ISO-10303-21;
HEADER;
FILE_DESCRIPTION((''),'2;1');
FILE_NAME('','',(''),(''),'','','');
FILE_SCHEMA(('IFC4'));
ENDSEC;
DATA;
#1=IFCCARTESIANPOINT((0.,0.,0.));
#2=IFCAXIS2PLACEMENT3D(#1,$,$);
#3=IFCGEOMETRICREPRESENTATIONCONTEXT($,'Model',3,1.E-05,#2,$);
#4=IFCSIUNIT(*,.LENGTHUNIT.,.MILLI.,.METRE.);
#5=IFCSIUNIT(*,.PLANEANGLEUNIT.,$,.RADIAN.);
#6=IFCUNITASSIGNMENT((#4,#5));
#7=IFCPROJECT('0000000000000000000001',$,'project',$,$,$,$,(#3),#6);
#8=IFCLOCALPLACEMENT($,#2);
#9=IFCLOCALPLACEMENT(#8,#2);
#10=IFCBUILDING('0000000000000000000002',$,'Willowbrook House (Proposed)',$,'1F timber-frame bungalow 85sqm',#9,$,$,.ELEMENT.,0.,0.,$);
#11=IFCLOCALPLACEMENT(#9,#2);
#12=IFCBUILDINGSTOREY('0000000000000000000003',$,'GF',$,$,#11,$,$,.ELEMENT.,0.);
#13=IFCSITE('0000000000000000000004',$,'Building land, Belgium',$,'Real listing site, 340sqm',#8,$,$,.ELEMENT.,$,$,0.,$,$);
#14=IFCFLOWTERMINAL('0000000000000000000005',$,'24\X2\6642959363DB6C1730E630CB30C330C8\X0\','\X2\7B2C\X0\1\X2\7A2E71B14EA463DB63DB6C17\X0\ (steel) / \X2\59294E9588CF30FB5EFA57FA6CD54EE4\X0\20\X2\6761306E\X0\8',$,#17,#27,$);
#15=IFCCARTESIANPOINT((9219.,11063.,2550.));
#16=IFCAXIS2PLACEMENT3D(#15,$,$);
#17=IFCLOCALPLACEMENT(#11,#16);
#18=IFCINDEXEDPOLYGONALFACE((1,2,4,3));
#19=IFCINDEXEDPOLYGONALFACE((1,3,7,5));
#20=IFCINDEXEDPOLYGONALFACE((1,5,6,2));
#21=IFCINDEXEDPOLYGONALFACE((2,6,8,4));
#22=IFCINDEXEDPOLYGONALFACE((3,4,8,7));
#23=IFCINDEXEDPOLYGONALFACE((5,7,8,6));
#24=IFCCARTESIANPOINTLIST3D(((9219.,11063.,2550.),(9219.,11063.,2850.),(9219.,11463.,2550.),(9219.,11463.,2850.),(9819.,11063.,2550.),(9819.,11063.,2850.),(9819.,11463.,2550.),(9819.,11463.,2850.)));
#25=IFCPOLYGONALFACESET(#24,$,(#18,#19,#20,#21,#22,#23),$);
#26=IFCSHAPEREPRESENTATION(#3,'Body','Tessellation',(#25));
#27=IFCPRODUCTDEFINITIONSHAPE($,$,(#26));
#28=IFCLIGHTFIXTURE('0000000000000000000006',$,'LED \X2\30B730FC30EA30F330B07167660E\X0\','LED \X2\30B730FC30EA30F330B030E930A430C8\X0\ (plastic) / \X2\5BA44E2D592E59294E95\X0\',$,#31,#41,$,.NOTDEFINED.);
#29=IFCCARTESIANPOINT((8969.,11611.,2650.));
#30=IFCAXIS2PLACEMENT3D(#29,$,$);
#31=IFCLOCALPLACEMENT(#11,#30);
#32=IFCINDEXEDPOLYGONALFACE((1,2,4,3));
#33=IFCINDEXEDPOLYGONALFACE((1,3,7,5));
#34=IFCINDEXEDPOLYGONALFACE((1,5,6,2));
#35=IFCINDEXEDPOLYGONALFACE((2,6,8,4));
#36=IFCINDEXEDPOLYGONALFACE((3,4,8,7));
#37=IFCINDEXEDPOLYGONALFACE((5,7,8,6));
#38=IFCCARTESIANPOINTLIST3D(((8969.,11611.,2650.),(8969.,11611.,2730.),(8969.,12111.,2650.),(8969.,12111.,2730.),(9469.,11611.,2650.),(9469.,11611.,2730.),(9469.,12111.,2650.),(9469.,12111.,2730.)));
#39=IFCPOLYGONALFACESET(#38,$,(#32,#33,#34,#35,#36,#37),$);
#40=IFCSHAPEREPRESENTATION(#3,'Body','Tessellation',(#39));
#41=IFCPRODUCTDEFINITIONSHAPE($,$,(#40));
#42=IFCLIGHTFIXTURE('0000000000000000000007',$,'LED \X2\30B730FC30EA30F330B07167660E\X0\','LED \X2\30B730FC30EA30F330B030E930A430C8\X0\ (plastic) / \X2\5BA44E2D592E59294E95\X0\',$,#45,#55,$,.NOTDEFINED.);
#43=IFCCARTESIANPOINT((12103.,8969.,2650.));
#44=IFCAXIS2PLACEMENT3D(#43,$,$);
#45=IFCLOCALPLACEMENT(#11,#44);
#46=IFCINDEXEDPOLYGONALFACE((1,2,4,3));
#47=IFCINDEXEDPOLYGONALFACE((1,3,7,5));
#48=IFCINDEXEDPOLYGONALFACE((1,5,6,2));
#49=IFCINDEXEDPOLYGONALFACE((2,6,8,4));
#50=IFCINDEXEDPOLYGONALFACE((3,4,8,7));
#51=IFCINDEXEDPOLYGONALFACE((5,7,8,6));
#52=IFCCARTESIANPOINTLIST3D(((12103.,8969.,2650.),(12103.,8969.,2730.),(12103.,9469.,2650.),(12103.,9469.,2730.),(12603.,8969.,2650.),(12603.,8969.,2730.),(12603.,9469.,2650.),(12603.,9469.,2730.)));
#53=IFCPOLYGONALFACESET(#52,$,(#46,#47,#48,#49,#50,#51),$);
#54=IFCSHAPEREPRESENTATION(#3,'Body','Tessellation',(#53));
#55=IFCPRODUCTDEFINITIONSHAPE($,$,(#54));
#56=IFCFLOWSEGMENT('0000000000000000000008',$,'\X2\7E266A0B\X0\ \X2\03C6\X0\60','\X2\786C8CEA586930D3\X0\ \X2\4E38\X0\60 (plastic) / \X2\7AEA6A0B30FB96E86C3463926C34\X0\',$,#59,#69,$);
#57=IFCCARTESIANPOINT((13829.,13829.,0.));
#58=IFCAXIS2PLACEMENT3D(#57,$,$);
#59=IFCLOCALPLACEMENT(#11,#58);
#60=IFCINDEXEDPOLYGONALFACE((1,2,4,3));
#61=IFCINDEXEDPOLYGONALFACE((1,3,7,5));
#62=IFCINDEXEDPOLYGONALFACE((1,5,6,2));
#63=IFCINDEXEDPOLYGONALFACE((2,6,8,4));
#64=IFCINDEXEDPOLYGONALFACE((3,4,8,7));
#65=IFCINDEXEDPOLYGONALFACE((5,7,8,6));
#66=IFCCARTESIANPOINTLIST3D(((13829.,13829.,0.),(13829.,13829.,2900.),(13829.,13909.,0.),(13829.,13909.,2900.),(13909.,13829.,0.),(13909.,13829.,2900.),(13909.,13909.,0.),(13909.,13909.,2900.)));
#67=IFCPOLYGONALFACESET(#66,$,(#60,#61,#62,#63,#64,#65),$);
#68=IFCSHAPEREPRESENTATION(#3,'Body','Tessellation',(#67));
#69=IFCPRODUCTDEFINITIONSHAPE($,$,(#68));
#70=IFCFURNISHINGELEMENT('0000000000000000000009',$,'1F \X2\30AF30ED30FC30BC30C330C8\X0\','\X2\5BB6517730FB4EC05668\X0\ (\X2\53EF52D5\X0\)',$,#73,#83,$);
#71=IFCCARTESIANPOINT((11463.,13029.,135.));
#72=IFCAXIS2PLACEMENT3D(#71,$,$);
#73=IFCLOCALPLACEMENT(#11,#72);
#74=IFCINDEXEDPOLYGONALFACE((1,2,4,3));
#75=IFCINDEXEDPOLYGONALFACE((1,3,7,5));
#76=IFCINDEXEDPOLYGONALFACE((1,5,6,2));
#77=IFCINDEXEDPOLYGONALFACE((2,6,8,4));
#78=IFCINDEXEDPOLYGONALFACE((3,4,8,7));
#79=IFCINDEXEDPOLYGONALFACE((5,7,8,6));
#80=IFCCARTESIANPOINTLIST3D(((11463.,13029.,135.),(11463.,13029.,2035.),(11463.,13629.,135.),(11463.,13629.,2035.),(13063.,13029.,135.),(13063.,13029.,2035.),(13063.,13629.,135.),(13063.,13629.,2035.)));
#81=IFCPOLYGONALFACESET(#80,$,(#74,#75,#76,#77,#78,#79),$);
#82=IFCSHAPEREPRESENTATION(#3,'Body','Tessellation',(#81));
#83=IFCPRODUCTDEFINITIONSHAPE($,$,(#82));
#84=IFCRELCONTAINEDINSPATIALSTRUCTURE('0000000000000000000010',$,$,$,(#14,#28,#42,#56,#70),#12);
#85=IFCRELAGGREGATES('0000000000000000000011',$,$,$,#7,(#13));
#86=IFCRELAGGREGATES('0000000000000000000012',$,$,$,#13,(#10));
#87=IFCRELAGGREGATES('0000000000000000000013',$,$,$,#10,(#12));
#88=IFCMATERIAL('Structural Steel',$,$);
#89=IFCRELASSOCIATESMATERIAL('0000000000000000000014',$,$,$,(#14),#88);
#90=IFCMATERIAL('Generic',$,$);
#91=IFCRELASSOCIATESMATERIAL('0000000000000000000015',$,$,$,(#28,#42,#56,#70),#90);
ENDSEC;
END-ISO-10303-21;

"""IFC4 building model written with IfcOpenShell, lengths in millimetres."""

from ifc_helpers import new_model, si_unit, frame, frame_2d, origin, place, context, project, spatial, rectangle, extrude, material, element, save


model = new_model("IFC4")

# Units and contexts
model_context = context("Model", 3, precision=1e-05, world=origin())
ifc_project = project(units=[si_unit("LENGTHUNIT", "METRE", prefix="MILLI"), si_unit("PLANEANGLEUNIT", "RADIAN")], contexts=[model_context])

# Site, building, storey
site_placement = place(None, origin())
site = spatial("IfcSite", under=ifc_project, at=site_placement, Name="Building land, Belgium", ObjectType="Real listing site, 340sqm", CompositionType="ELEMENT", RefElevation=0.0)
building_placement = place(site_placement, origin())
building = spatial("IfcBuilding", under=site, at=building_placement, Name="Willowbrook House (Proposed)", ObjectType="1F timber-frame bungalow 85sqm", CompositionType="ELEMENT", ElevationOfRefHeight=0.0, ElevationOfTerrain=0.0)
storey_placement = place(building_placement, origin())
storey = spatial("IfcBuildingStorey", under=building, at=storey_placement, Name="GF", CompositionType="ELEMENT", Elevation=0.0)

# Shared definitions
ifc_material_1 = material(Name="Generic")

# Flow terminal
ifc_material_2 = material(Name="Structural Steel")
flow_terminal_placement = place(storey_placement, frame((9219.0, 11063.0, 2550.0)))
element("IfcFlowTerminal", 1, at=flow_terminal_placement, inside=storey, material=ifc_material_2, Name="24時間換気ユニット", Description="第1種熱交換換気 (steel) / 天井裏・建基法令20条の8", context=model_context, shape_type="SweptSolid", body=[
    extrude(rectangle(XDim=600.0, YDim=400.0, at=frame_2d((300.0, 200.0))), frame((9219.0, 11063.0, 2550.0)), (0.0, 0.0, 1.0), 300.0),
])

# Light fixtures
light_fixture_1_placement = place(storey_placement, frame((8969.0, 11611.0, 2650.0)))
element("IfcLightFixture", 2, at=light_fixture_1_placement, inside=storey, material=ifc_material_1, Name="LED シーリング照明", Description="LED シーリングライト (plastic) / 室中央天井", PredefinedType="NOTDEFINED", context=model_context, shape_type="SweptSolid", body=[
    extrude(rectangle(XDim=500.0, YDim=500.0, at=frame_2d((250.0, 250.0))), frame((8969.0, 11611.0, 2650.0)), (0.0, 0.0, 1.0), 80.0),
])
light_fixture_2_placement = place(storey_placement, frame((12103.0, 8969.0, 2650.0)))
element("IfcLightFixture", 3, at=light_fixture_2_placement, inside=storey, material=ifc_material_1, Name="LED シーリング照明", Description="LED シーリングライト (plastic) / 室中央天井", PredefinedType="NOTDEFINED", context=model_context, shape_type="SweptSolid", body=[
    extrude(rectangle(XDim=500.0, YDim=500.0, at=frame_2d((250.0, 250.0))), frame((12103.0, 8969.0, 2650.0)), (0.0, 0.0, 1.0), 80.0),
])

# Flow segment
flow_segment_placement = place(storey_placement, frame((13829.0, 13829.0, 0.0)))
element("IfcFlowSegment", 4, at=flow_segment_placement, inside=storey, material=ifc_material_1, Name="縦樋 φ60", Description="硬質塩ビ 丸60 (plastic) / 竪樋・雨水排水", context=model_context, shape_type="SweptSolid", body=[
    extrude(rectangle(XDim=80.0, YDim=80.0, at=frame_2d((40.0, 40.0))), frame((13829.0, 13829.0, 0.0)), (0.0, 0.0, 1.0), 2900.0),
])

# Furnishing element
furnishing_placement = place(storey_placement, frame((11463.0, 13029.0, 135.0)))
element("IfcFurnishingElement", 5, at=furnishing_placement, inside=storey, material=ifc_material_1, Name="1F クローゼット", Description="家具・什器 (可動)", context=model_context, shape_type="SweptSolid", body=[
    extrude(rectangle(XDim=1600.0, YDim=600.0, at=frame_2d((800.0, 300.0))), frame((11463.0, 13029.0, 135.0)), (0.0, 0.0, 1.0), 1900.0),
])

save(model, "model.ifc")
